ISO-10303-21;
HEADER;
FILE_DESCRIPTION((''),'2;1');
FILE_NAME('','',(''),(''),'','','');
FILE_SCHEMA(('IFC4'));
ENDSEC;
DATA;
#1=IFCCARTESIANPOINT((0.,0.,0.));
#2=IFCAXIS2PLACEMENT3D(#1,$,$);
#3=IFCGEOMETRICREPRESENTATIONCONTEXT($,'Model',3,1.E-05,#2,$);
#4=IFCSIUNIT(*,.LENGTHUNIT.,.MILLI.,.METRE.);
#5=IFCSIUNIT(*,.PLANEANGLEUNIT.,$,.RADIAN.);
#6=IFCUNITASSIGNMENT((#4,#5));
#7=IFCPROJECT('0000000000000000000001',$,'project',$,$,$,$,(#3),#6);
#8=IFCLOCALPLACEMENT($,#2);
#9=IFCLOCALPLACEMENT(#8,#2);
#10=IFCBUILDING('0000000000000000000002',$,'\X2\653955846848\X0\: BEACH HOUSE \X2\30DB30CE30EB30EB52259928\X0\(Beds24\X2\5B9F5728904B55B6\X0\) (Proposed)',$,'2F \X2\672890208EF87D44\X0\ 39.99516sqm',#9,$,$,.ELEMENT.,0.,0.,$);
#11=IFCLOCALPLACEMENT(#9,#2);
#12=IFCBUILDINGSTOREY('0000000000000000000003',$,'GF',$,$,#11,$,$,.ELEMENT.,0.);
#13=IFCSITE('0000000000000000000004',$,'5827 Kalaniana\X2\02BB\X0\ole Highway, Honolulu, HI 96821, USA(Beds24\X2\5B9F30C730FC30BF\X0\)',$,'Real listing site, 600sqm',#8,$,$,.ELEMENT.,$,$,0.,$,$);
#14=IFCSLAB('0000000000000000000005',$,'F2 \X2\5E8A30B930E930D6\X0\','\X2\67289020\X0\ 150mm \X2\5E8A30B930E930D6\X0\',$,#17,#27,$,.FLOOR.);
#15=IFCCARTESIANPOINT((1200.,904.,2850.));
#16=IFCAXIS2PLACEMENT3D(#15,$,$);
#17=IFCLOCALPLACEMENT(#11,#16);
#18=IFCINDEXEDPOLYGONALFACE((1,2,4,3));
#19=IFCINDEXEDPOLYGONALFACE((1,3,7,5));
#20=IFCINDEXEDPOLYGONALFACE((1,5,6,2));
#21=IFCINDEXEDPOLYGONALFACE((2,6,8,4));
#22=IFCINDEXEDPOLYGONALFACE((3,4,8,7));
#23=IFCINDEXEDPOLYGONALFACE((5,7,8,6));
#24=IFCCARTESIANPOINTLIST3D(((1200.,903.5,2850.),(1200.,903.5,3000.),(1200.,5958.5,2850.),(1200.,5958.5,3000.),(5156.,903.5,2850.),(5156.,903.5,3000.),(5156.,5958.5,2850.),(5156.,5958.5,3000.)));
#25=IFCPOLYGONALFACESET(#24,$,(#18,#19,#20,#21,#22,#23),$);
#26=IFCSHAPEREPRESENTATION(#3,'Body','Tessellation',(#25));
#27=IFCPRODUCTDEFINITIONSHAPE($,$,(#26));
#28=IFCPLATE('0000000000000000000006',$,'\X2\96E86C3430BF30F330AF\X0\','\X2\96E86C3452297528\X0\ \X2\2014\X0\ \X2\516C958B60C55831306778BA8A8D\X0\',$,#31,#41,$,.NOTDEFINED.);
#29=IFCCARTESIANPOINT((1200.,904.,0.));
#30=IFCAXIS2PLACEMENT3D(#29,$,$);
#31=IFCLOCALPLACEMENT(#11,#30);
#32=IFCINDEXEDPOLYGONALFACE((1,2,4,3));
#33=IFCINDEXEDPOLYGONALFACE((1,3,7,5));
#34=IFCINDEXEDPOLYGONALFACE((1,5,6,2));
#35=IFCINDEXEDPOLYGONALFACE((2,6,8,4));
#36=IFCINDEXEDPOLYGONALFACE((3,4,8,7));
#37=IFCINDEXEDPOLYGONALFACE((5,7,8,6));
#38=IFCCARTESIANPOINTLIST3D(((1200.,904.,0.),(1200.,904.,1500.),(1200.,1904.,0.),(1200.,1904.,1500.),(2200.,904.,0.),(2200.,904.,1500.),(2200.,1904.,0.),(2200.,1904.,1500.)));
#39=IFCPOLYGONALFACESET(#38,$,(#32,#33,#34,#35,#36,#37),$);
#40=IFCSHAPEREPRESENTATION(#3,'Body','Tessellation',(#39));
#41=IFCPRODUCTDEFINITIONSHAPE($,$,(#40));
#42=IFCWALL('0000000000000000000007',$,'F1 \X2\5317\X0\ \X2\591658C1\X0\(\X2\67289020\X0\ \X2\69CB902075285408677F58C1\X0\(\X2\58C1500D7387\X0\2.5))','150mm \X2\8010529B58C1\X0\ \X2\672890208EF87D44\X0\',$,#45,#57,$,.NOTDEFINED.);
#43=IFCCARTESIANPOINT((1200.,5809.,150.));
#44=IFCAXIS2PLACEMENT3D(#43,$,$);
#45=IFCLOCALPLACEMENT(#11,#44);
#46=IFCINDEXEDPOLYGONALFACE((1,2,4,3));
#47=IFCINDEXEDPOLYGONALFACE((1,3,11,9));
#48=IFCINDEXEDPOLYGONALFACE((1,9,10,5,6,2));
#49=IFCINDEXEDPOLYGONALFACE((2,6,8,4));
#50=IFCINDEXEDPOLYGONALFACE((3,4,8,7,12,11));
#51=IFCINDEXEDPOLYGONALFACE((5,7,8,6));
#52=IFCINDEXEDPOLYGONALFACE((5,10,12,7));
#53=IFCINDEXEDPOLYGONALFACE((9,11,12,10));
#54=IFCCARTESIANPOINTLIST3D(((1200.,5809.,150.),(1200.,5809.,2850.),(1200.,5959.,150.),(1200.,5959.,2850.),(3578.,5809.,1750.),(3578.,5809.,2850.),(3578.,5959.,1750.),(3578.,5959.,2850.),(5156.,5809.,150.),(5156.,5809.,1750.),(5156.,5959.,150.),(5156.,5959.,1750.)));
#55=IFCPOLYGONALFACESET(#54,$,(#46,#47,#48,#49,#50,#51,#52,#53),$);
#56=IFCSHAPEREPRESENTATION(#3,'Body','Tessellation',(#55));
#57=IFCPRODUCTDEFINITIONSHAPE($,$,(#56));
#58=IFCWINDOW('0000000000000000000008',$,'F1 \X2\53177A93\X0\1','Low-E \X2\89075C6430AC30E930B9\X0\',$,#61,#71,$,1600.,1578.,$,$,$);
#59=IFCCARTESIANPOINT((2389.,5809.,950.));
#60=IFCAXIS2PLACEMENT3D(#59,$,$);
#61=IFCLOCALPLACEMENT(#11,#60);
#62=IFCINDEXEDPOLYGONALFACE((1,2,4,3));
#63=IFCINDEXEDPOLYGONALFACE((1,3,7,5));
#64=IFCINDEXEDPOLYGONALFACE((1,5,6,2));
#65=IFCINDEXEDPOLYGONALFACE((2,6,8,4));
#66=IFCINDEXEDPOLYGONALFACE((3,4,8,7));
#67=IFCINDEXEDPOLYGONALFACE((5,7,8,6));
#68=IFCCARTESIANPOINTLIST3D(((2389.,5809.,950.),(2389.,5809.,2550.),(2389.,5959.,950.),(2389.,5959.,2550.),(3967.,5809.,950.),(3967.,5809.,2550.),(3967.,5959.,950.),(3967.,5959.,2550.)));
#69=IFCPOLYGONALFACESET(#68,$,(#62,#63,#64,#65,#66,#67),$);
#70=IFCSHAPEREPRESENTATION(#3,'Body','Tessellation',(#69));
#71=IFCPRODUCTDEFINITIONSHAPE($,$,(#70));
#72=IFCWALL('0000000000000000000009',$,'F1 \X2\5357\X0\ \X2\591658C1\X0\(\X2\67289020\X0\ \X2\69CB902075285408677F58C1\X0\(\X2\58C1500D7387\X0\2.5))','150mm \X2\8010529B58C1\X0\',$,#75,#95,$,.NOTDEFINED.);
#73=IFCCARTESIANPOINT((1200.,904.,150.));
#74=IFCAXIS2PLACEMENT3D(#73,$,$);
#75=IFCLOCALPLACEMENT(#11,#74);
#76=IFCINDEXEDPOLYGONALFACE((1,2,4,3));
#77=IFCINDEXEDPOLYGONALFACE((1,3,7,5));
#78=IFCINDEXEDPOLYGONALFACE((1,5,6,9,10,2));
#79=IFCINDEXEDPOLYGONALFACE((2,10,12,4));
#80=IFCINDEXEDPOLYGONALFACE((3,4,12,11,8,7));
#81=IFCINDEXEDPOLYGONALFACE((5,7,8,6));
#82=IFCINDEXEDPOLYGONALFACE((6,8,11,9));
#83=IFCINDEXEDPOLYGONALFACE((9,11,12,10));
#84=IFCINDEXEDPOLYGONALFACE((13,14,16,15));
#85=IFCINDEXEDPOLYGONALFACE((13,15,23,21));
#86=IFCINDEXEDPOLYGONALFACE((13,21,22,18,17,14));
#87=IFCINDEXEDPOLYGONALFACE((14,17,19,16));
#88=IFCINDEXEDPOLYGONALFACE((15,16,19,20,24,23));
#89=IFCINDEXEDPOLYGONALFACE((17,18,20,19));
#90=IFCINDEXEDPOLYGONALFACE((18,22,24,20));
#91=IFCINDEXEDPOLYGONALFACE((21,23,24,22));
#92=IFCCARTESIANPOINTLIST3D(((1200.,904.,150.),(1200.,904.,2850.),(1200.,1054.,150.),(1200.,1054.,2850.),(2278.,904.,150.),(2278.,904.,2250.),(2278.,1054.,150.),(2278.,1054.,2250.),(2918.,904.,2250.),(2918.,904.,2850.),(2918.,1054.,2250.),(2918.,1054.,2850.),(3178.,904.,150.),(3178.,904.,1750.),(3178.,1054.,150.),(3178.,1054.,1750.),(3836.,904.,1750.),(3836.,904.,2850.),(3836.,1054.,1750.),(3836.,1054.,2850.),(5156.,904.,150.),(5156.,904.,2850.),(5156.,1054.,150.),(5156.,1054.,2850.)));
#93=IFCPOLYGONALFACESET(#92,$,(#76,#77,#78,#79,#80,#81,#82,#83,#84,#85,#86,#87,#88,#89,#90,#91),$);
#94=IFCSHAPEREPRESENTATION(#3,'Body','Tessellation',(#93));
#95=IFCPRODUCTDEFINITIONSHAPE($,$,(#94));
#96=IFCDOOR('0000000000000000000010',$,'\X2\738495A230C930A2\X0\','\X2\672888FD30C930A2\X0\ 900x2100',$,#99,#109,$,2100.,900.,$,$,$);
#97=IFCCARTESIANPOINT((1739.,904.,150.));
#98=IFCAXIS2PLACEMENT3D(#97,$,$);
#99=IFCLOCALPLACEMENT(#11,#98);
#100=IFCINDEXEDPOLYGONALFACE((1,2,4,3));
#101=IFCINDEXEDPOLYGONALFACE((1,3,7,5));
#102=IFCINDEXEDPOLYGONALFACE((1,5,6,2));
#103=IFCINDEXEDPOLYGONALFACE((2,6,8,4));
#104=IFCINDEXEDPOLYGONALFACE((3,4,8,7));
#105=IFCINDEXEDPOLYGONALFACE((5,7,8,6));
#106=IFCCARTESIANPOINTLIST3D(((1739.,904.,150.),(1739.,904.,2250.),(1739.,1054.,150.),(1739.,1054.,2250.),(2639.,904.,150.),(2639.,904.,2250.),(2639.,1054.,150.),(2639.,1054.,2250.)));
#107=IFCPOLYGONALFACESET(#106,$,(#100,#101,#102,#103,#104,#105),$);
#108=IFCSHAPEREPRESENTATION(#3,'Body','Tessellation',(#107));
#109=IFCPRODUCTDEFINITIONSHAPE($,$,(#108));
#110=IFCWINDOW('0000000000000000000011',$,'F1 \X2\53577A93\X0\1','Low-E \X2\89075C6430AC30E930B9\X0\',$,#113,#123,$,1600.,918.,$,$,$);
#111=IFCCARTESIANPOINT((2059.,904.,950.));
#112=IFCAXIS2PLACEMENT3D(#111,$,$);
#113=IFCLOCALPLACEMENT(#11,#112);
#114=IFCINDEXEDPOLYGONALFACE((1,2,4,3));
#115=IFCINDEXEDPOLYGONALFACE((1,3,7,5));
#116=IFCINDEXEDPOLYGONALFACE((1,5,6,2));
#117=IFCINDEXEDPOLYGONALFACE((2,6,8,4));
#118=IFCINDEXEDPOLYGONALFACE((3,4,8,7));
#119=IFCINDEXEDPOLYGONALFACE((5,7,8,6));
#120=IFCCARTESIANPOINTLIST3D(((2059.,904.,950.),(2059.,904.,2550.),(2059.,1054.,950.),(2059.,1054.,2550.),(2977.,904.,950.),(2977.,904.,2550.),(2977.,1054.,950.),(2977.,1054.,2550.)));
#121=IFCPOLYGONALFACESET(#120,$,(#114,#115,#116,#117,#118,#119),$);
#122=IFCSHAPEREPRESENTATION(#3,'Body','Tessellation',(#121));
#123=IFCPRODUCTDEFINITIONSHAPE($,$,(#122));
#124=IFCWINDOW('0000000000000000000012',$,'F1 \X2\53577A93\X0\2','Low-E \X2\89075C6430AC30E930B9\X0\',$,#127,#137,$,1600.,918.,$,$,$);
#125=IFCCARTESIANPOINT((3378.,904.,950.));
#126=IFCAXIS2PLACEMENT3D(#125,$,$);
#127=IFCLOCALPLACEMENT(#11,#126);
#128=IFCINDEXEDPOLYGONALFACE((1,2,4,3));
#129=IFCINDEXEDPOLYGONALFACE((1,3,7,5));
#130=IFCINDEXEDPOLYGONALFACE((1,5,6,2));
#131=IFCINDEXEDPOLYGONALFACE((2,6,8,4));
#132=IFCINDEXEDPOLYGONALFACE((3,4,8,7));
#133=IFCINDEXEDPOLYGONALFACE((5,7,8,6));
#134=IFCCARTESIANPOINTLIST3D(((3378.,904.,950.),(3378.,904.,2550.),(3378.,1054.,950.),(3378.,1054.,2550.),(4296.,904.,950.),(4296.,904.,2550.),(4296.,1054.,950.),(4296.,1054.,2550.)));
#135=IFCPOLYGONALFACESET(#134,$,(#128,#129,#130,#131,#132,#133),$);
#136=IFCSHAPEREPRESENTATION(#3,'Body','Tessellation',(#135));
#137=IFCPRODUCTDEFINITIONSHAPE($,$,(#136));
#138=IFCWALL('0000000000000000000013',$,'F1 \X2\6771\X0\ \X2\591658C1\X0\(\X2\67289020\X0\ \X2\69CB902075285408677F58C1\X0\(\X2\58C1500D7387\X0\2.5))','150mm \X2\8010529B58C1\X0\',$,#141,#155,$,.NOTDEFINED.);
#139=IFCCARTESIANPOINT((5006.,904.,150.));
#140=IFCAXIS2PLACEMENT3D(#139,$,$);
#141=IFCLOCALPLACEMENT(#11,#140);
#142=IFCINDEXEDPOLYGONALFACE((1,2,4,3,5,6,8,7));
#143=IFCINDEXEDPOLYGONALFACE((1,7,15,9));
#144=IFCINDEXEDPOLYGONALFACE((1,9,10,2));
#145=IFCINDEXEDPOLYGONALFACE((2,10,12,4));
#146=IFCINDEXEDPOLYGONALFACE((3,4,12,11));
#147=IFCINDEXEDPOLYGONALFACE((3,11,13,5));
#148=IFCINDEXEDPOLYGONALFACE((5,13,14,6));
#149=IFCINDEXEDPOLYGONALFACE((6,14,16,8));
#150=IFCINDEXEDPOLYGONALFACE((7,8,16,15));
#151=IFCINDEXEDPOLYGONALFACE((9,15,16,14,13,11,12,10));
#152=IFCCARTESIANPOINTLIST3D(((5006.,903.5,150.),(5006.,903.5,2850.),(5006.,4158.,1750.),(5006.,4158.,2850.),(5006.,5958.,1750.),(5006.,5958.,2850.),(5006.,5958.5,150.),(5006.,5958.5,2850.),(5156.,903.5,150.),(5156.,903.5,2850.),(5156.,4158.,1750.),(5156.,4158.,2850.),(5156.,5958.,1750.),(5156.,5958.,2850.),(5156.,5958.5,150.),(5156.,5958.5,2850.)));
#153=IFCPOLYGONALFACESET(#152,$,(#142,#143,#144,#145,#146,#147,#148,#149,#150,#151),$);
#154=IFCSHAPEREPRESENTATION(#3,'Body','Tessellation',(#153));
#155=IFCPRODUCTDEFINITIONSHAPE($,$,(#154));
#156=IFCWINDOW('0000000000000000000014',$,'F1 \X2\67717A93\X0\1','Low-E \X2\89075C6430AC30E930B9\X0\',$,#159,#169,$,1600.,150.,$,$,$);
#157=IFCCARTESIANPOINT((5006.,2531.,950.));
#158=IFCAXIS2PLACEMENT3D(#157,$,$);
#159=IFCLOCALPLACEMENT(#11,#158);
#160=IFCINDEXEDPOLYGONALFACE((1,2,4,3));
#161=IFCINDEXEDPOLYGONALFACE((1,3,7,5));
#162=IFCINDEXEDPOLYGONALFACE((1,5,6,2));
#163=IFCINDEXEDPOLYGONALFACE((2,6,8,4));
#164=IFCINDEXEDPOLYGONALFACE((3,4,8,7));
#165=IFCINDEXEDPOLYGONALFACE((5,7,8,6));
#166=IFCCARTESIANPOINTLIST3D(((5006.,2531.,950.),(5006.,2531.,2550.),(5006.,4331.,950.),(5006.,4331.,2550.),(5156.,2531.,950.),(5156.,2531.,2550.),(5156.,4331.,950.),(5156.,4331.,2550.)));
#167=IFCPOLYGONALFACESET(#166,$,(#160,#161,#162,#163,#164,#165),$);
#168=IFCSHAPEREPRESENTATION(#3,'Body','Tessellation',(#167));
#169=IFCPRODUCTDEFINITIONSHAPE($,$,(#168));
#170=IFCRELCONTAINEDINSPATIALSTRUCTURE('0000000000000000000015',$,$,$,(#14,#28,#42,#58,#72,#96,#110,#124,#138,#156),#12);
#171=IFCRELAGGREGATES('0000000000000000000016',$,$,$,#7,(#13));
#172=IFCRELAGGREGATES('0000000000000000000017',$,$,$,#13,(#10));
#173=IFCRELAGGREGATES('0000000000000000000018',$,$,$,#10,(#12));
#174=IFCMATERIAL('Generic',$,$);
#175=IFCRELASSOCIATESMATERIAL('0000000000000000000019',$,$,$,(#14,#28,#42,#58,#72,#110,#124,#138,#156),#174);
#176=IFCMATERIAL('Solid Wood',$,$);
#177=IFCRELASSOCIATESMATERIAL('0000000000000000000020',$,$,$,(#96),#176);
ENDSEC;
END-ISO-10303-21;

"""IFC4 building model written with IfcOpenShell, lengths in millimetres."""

from ifc_helpers import new_model, si_unit, frame, frame_2d, origin, place, context, project, spatial, rectangle, extrude, material, element, fill, save


model = new_model("IFC4")

# Units and contexts
model_context = context("Model", 3, precision=1e-05, world=origin())
ifc_project = project(units=[si_unit("LENGTHUNIT", "METRE", prefix="MILLI"), si_unit("PLANEANGLEUNIT", "RADIAN")], contexts=[model_context])

# Site, building, storey
site_placement = place(None, origin())
site = spatial("IfcSite", under=ifc_project, at=site_placement, Name="5827 Kalanianaʻole Highway, Honolulu, HI 96821, USA(Beds24実データ)", ObjectType="Real listing site, 600sqm", CompositionType="ELEMENT", RefElevation=0.0)
building_placement = place(site_placement, origin())
building = spatial("IfcBuilding", under=site, at=building_placement, Name="改善案: BEACH HOUSE ホノルル別館(Beds24実在運営) (Proposed)", ObjectType="2F 木造軸組 39.99516sqm", CompositionType="ELEMENT", ElevationOfRefHeight=0.0, ElevationOfTerrain=0.0)
storey_placement = place(building_placement, origin())
storey = spatial("IfcBuildingStorey", under=building, at=storey_placement, Name="GF", CompositionType="ELEMENT", Elevation=0.0)

# Slab
ifc_material_1 = material(Name="Generic")
slab_1_placement = place(storey_placement, frame((1200.0, 904.0, 2850.0)))
element("IfcSlab", 1, at=slab_1_placement, inside=storey, material=ifc_material_1, Name="F2 床スラブ", Description="木造 150mm 床スラブ", PredefinedType="FLOOR", context=model_context, shape_type="SweptSolid", body=[
    extrude(rectangle(XDim=3956.0, YDim=5055.0, at=frame_2d((1978.0, 2527.0))), frame((1200.0, 904.0, 2850.0)), (0.0, 0.0, 1.0), 150.0),
])

# Plate
plate_placement = place(storey_placement, frame((1200.0, 904.0, 0.0)))
element("IfcPlate", 2, at=plate_placement, inside=storey, material=ifc_material_1, Name="雨水タンク", Description="雨水利用 — 公開情報で確認", PredefinedType="NOTDEFINED", context=model_context, shape_type="SweptSolid", body=[
    extrude(rectangle(XDim=1000.0, YDim=1000.0, at=frame_2d((500.0, 500.0))), frame((1200.0, 904.0, 0.0)), (0.0, 0.0, 1.0), 1500.0),
])

# Wall, opening, window
wall_1_placement = place(storey_placement, frame((1200.0, 5809.0, 150.0)))
wall_1 = element("IfcWall", 3, at=wall_1_placement, inside=storey, material=ifc_material_1, Name="F1 北 外壁(木造 構造用合板壁(壁倍率2.5))", Description="150mm 耐力壁 木造軸組", PredefinedType="NOTDEFINED", context=model_context, shape_type="SweptSolid", body=[
    extrude(rectangle(XDim=3956.0, YDim=150.0, at=frame_2d((1978.0, 75.0))), frame((1200.0, 5809.0, 150.0)), (0.0, 0.0, 1.0), 2700.0),
])
opening_1_placement = place(storey_placement, frame((2389.0, 5809.0, 950.0)))
opening_1 = element("IfcOpeningElement", 4, at=opening_1_placement, cuts=wall_1, PredefinedType="NOTDEFINED", context=model_context, shape_type="SweptSolid", body=[
    extrude(rectangle(XDim=1578.0, YDim=150.0, at=frame_2d((789.0, 75.0))), frame((2389.0, 5809.0, 950.0)), (0.0, 0.0, 1.0), 1600.0),
])
window_1_placement = place(storey_placement, frame((2389.0, 5809.0, 950.0)))
window_1 = element("IfcWindow", 5, at=window_1_placement, inside=storey, material=ifc_material_1, Name="F1 北窓1", Description="Low-E 複層ガラス", OverallHeight=1600.0, OverallWidth=1578.0, context=model_context, shape_type="SweptSolid", body=[
    extrude(rectangle(XDim=1578.0, YDim=150.0, at=frame_2d((789.0, 75.0))), frame((2389.0, 5809.0, 950.0)), (0.0, 0.0, 1.0), 1600.0),
])
fill(opening_1, window_1)

# Wall, openings, door, windows
wall_2_placement = place(storey_placement, frame((1200.0, 904.0, 150.0)))
wall_2 = element("IfcWall", 6, at=wall_2_placement, inside=storey, material=ifc_material_1, Name="F1 南 外壁(木造 構造用合板壁(壁倍率2.5))", Description="150mm 耐力壁", PredefinedType="NOTDEFINED", context=model_context, shape_type="SweptSolid", body=[
    extrude(rectangle(XDim=3956.0, YDim=150.0, at=frame_2d((1978.0, 75.0))), frame((1200.0, 904.0, 150.0)), (0.0, 0.0, 1.0), 2700.0),
])
opening_2_placement = place(storey_placement, frame((1739.0, 904.0, 150.0)))
opening_2 = element("IfcOpeningElement", 7, at=opening_2_placement, cuts=wall_2, PredefinedType="NOTDEFINED", context=model_context, shape_type="SweptSolid", body=[
    extrude(rectangle(XDim=900.0, YDim=150.0, at=frame_2d((450.0, 75.0))), frame((1739.0, 904.0, 150.0)), (0.0, 0.0, 1.0), 2100.0),
])
opening_3_placement = place(storey_placement, frame((2059.0, 904.0, 950.0)))
opening_3 = element("IfcOpeningElement", 8, at=opening_3_placement, cuts=wall_2, PredefinedType="NOTDEFINED", context=model_context, shape_type="SweptSolid", body=[
    extrude(rectangle(XDim=918.0, YDim=150.0, at=frame_2d((459.0, 75.0))), frame((2059.0, 904.0, 950.0)), (0.0, 0.0, 1.0), 1600.0),
])
opening_4_placement = place(storey_placement, frame((3378.0, 904.0, 950.0)))
opening_4 = element("IfcOpeningElement", 9, at=opening_4_placement, cuts=wall_2, PredefinedType="NOTDEFINED", context=model_context, shape_type="SweptSolid", body=[
    extrude(rectangle(XDim=918.0, YDim=150.0, at=frame_2d((459.0, 75.0))), frame((3378.0, 904.0, 950.0)), (0.0, 0.0, 1.0), 1600.0),
])
ifc_material_2 = material(Name="Solid Wood")
door_placement = place(storey_placement, frame((1739.0, 904.0, 150.0)))
door = element("IfcDoor", 10, at=door_placement, inside=storey, material=ifc_material_2, Name="玄関ドア", Description="木製ドア 900x2100", OverallHeight=2100.0, OverallWidth=900.0, context=model_context, shape_type="SweptSolid", body=[
    extrude(rectangle(XDim=900.0, YDim=150.0, at=frame_2d((450.0, 75.0))), frame((1739.0, 904.0, 150.0)), (0.0, 0.0, 1.0), 2100.0),
])
fill(opening_2, door)
window_2_placement = place(storey_placement, frame((2059.0, 904.0, 950.0)))
window_2 = element("IfcWindow", 11, at=window_2_placement, inside=storey, material=ifc_material_1, Name="F1 南窓1", Description="Low-E 複層ガラス", OverallHeight=1600.0, OverallWidth=918.0, context=model_context, shape_type="SweptSolid", body=[
    extrude(rectangle(XDim=918.0, YDim=150.0, at=frame_2d((459.0, 75.0))), frame((2059.0, 904.0, 950.0)), (0.0, 0.0, 1.0), 1600.0),
])
fill(opening_3, window_2)
window_3_placement = place(storey_placement, frame((3378.0, 904.0, 950.0)))
window_3 = element("IfcWindow", 12, at=window_3_placement, inside=storey, material=ifc_material_1, Name="F1 南窓2", Description="Low-E 複層ガラス", OverallHeight=1600.0, OverallWidth=918.0, context=model_context, shape_type="SweptSolid", body=[
    extrude(rectangle(XDim=918.0, YDim=150.0, at=frame_2d((459.0, 75.0))), frame((3378.0, 904.0, 950.0)), (0.0, 0.0, 1.0), 1600.0),
])
fill(opening_4, window_3)

# Wall, opening, window
wall_3_placement = place(storey_placement, frame((5006.0, 904.0, 150.0)))
wall_3 = element("IfcWall", 13, at=wall_3_placement, inside=storey, material=ifc_material_1, Name="F1 東 外壁(木造 構造用合板壁(壁倍率2.5))", Description="150mm 耐力壁", PredefinedType="NOTDEFINED", context=model_context, shape_type="SweptSolid", body=[
    extrude(rectangle(XDim=150.0, YDim=5055.0, at=frame_2d((75.0, 2527.0))), frame((5006.0, 904.0, 150.0)), (0.0, 0.0, 1.0), 2700.0),
])
opening_5_placement = place(storey_placement, frame((5006.0, 2531.0, 950.0)))
opening_5 = element("IfcOpeningElement", 14, at=opening_5_placement, cuts=wall_3, PredefinedType="NOTDEFINED", context=model_context, shape_type="SweptSolid", body=[
    extrude(rectangle(XDim=150.0, YDim=1800.0, at=frame_2d((75.0, 900.0))), frame((5006.0, 2531.0, 950.0)), (0.0, 0.0, 1.0), 1600.0),
])
window_4_placement = place(storey_placement, frame((5006.0, 2531.0, 950.0)))
window_4 = element("IfcWindow", 15, at=window_4_placement, inside=storey, material=ifc_material_1, Name="F1 東窓1", Description="Low-E 複層ガラス", OverallHeight=1600.0, OverallWidth=150.0, context=model_context, shape_type="SweptSolid", body=[
    extrude(rectangle(XDim=150.0, YDim=1800.0, at=frame_2d((75.0, 900.0))), frame((5006.0, 2531.0, 950.0)), (0.0, 0.0, 1.0), 1600.0),
])
fill(opening_5, window_4)

save(model, "model.ifc")
